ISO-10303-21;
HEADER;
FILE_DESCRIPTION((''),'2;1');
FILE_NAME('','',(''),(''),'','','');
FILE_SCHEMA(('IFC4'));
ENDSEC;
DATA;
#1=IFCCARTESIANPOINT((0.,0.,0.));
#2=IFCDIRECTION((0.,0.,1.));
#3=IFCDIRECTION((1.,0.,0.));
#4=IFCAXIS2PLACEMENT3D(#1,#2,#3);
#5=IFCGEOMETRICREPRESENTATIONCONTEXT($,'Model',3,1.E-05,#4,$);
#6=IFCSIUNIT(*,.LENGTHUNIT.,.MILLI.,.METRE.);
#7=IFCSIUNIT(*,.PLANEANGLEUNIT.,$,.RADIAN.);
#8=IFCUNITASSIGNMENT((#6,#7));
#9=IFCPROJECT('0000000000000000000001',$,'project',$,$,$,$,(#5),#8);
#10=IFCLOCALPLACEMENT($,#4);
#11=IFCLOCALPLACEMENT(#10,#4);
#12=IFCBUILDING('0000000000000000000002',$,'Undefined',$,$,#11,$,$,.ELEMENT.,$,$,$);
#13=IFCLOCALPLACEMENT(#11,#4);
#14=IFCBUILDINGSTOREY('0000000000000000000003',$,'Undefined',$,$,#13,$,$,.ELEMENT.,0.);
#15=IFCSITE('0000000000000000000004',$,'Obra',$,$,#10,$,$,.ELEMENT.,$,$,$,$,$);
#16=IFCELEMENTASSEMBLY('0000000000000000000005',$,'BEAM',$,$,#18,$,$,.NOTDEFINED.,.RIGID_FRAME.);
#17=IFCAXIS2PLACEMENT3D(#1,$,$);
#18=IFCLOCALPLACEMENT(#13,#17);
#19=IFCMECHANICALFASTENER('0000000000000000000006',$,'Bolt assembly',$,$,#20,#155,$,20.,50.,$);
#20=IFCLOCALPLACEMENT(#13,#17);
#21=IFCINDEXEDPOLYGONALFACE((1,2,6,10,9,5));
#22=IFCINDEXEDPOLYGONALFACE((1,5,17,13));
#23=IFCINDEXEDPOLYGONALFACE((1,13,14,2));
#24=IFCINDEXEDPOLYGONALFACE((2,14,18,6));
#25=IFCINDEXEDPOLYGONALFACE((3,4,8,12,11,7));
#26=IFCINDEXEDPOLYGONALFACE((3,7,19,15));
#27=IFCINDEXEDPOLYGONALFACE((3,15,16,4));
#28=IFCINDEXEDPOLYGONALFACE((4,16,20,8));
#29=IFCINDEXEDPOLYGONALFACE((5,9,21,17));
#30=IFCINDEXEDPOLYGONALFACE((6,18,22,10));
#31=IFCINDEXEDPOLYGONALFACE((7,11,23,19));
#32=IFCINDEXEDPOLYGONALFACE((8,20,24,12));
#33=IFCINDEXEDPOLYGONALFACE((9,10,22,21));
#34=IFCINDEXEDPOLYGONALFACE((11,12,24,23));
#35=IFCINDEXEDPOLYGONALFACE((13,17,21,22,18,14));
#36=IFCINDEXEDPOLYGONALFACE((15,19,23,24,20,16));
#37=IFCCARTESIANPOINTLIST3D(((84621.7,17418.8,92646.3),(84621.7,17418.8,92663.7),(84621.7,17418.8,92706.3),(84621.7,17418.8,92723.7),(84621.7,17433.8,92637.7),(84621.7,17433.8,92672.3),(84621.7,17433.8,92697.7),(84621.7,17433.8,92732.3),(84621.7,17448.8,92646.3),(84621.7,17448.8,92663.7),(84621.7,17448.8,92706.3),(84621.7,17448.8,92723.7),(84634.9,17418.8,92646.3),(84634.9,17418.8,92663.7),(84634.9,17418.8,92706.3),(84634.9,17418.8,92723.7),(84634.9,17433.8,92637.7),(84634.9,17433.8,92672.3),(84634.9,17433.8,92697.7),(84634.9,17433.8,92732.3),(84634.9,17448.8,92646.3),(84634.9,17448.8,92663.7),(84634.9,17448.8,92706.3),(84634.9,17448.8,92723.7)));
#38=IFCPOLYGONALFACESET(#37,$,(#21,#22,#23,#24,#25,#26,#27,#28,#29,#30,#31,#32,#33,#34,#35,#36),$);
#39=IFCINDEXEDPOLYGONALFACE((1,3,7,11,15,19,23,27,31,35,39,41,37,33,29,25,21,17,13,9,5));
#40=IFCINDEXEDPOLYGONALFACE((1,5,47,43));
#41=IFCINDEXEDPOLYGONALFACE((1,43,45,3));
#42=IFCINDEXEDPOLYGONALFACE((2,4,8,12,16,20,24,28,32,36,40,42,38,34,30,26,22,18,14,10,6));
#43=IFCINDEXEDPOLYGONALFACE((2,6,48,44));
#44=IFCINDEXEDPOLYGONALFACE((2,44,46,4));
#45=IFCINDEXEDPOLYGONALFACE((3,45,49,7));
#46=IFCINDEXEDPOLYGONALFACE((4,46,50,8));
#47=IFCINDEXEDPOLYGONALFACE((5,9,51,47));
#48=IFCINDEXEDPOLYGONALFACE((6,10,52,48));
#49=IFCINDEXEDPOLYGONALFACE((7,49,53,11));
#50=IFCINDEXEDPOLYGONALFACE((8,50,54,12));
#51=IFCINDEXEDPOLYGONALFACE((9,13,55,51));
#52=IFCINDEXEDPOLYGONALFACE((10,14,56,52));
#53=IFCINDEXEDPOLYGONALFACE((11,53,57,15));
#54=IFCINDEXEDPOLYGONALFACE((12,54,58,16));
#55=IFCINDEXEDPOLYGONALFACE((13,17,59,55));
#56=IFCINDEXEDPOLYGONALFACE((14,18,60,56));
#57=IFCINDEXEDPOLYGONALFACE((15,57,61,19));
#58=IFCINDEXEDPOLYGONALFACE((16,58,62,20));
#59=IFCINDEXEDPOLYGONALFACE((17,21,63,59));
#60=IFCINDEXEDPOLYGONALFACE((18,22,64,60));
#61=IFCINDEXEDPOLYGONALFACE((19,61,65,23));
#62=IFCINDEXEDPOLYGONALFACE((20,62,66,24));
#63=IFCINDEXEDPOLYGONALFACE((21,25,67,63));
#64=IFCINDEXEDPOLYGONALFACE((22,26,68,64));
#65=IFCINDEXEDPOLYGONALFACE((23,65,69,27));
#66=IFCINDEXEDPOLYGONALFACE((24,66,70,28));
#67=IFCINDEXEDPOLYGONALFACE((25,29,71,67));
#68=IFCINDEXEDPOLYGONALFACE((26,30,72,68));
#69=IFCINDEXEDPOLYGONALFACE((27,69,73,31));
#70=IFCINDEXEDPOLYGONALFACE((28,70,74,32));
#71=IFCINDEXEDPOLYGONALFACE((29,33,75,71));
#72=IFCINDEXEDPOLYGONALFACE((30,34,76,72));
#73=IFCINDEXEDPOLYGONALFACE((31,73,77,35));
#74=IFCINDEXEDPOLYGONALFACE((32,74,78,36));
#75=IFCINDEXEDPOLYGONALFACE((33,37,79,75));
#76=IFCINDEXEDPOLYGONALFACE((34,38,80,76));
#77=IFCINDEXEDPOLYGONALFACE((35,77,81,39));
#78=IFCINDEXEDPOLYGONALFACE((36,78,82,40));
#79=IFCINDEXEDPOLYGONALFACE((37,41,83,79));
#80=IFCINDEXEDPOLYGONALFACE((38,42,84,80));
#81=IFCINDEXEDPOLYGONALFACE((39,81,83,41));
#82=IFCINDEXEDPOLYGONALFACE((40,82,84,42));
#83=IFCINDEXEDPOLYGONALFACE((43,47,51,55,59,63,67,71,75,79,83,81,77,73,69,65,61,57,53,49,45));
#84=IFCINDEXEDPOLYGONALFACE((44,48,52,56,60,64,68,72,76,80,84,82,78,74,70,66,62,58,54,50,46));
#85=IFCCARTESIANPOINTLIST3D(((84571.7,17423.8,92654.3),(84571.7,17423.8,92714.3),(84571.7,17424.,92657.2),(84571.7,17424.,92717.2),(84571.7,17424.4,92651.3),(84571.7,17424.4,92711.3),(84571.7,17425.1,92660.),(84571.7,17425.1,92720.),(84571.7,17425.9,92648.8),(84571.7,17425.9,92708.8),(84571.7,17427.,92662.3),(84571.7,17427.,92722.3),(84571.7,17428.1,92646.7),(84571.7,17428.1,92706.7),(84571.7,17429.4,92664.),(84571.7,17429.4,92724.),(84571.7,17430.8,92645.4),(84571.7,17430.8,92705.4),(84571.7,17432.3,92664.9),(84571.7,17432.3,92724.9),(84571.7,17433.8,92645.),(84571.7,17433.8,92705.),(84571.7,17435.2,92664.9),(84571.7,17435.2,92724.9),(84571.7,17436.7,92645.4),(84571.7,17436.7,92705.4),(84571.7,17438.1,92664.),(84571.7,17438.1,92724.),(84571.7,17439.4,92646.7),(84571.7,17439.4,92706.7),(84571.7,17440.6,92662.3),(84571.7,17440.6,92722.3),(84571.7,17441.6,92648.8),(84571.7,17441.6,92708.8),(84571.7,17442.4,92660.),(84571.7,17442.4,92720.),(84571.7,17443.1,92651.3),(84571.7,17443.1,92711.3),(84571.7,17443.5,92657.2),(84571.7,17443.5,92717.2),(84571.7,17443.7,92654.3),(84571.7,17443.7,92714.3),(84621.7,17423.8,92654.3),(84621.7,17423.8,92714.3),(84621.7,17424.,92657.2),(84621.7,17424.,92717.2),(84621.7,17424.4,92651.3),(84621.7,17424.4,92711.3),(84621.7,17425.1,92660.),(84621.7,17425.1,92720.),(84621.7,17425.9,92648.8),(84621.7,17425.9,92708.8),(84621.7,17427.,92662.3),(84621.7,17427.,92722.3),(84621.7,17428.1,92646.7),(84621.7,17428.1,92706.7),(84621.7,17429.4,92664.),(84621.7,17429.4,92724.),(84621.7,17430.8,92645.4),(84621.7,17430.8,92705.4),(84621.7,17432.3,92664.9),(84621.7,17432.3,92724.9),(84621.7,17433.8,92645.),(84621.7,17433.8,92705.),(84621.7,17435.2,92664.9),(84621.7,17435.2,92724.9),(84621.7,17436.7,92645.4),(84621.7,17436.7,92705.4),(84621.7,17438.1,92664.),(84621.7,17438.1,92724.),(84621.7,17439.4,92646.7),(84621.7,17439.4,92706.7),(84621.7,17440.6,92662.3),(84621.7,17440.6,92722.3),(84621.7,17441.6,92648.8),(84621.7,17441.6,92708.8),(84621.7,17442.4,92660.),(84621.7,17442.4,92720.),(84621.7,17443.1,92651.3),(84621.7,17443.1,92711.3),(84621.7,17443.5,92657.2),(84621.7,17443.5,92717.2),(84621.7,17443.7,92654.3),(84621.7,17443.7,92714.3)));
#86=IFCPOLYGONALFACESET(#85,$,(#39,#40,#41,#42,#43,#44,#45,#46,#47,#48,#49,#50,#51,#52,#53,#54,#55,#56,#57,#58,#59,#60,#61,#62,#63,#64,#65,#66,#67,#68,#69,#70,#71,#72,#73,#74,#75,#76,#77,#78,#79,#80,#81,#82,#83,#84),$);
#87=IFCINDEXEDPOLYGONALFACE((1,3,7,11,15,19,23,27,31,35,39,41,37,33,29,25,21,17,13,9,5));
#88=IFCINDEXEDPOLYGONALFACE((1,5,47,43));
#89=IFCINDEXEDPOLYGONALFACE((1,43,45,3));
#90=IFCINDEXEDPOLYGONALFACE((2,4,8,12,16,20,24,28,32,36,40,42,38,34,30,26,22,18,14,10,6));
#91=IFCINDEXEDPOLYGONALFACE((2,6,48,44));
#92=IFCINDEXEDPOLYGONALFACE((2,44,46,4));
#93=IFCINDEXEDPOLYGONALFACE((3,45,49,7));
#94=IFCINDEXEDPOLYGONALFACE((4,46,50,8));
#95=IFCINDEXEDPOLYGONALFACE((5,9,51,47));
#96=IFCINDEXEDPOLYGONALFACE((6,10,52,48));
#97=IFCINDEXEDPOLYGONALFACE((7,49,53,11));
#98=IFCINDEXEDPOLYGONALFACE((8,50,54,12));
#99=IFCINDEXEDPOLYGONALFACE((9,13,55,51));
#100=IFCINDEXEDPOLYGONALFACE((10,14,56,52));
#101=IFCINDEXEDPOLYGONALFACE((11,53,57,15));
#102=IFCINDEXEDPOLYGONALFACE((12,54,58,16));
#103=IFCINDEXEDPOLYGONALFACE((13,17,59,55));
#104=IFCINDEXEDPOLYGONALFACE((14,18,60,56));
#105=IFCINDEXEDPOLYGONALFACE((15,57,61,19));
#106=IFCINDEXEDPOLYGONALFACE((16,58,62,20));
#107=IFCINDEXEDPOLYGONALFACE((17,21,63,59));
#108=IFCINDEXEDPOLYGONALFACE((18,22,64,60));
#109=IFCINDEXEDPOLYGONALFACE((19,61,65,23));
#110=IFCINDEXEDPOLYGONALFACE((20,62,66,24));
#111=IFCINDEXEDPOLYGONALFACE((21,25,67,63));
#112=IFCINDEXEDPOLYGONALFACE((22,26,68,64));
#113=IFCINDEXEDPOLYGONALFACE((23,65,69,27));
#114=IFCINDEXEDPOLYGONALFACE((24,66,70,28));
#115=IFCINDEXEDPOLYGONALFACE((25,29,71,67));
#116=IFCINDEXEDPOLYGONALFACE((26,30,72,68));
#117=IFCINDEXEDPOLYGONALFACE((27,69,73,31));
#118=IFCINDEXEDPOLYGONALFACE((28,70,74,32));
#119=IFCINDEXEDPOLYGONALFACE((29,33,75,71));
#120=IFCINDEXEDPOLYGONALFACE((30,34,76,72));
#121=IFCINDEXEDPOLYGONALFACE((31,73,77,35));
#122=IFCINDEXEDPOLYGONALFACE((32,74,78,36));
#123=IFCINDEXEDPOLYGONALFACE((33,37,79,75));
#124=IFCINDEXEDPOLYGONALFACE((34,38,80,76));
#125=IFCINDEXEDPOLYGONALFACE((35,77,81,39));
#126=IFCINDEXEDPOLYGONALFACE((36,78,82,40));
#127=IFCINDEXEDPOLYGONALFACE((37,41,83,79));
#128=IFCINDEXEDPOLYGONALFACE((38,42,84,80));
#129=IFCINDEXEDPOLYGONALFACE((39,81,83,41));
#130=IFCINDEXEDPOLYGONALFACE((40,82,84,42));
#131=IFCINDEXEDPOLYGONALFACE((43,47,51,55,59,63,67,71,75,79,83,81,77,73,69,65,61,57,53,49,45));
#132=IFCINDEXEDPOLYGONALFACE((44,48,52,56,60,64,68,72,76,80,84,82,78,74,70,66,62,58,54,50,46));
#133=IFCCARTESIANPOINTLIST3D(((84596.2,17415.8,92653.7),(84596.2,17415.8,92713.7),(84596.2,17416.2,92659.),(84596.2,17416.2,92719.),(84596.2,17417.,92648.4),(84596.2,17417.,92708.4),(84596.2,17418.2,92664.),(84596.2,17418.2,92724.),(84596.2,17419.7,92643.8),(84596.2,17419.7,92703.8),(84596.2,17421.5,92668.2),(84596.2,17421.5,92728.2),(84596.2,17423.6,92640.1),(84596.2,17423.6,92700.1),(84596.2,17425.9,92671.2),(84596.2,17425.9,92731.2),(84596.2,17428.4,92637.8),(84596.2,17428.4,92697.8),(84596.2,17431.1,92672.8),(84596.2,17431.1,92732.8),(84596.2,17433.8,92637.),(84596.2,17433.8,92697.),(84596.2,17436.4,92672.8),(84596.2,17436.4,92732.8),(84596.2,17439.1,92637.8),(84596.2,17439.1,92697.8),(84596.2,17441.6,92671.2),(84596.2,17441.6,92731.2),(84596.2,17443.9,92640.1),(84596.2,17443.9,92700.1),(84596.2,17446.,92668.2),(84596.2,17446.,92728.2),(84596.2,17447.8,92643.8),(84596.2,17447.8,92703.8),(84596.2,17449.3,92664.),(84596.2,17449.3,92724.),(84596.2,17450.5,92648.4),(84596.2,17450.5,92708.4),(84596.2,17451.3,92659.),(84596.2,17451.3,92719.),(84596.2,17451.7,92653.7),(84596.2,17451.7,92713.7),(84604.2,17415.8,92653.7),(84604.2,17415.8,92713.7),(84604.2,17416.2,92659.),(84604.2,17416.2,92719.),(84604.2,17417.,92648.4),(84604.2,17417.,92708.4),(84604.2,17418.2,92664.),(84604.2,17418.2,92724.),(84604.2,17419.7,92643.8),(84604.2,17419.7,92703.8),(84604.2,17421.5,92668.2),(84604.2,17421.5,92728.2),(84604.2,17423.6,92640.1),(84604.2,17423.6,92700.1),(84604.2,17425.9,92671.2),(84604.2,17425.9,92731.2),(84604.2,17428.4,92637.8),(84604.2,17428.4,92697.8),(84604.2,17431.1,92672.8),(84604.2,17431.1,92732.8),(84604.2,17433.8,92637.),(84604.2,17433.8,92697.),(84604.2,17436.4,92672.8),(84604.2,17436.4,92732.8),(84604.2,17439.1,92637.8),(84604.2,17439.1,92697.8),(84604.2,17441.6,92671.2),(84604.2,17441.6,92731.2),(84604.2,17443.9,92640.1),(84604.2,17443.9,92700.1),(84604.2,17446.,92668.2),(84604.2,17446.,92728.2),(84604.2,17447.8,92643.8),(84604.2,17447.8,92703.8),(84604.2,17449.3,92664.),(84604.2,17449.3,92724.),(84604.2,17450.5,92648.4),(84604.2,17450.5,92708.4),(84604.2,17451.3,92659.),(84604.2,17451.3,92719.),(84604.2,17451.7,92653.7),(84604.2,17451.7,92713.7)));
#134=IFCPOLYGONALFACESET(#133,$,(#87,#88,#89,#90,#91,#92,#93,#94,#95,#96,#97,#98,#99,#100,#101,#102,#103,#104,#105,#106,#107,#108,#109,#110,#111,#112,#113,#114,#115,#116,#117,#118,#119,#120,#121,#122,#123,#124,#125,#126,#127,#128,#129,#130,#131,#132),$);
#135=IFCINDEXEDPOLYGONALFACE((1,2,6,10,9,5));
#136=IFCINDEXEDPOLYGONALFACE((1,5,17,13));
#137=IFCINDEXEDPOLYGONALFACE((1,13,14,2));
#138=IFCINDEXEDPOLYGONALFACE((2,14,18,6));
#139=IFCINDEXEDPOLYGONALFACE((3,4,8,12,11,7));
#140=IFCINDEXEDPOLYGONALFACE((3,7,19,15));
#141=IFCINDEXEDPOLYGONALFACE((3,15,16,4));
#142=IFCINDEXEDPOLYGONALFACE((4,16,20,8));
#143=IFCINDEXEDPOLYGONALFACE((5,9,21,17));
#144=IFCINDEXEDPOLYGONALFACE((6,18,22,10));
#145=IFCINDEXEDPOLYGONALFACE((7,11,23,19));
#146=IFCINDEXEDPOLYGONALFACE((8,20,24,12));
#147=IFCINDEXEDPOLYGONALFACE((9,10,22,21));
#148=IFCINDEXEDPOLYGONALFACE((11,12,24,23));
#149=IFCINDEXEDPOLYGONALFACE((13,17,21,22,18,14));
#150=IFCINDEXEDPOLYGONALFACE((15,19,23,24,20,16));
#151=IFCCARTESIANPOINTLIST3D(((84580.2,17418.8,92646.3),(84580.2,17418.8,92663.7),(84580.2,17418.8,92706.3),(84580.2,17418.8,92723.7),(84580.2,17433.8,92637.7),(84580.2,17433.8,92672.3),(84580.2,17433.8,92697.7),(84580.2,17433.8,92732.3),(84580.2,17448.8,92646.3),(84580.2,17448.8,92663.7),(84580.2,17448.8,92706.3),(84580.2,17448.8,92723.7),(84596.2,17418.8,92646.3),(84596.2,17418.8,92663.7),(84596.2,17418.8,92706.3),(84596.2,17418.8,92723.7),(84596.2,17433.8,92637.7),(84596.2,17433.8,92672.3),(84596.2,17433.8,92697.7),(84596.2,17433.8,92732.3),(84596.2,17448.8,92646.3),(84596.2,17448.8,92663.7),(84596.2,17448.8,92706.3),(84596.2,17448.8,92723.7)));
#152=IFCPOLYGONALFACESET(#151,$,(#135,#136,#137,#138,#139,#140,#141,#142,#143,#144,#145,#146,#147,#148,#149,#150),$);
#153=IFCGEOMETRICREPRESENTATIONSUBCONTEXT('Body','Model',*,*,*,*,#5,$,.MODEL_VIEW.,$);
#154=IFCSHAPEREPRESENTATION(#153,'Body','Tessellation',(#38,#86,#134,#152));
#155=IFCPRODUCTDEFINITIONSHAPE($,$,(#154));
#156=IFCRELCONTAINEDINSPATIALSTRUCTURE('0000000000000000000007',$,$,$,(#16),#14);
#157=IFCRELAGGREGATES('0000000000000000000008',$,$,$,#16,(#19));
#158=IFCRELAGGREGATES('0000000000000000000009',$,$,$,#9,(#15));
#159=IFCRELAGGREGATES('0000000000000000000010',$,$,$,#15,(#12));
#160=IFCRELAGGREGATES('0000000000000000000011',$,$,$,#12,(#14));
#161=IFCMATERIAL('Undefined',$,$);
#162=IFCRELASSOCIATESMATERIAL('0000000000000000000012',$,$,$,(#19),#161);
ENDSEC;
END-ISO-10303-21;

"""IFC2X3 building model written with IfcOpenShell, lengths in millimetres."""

from ifc_helpers import new_model, si_unit, frame, origin_with_axes, origin_2d_with_axis, place, context, subcontext, project, spatial, polyline, circle, outline, extrude, source, transform, mapped, material, element, aggregate, save


model = new_model("IFC2X3")

# Units and contexts
model_context = context("Model", 3, precision=1e-05, world=origin_with_axes())
body_context = subcontext(model_context, "Body", "Model", "MODEL_VIEW")
ifc_project = project(units=[si_unit("LENGTHUNIT", "METRE", prefix="MILLI"), si_unit("PLANEANGLEUNIT", "RADIAN")], contexts=[model_context])

# Site, building, storey
site_placement = place(None, origin_with_axes())
site = spatial("IfcSite", under=ifc_project, at=site_placement, Name="Obra", CompositionType="ELEMENT")
building_placement = place(site_placement, origin_with_axes())
building = spatial("IfcBuilding", under=site, at=building_placement, Name="Undefined", CompositionType="ELEMENT")
storey_placement = place(building_placement, origin_with_axes())
storey = spatial("IfcBuildingStorey", under=building, at=storey_placement, Name="Undefined", CompositionType="ELEMENT", Elevation=0.0)

# Shared definitions
ifc_material_1 = material(Name="Undefined")

# Element assembly, mechanical fastener
assembly_1_placement = place(storey_placement, origin_with_axes())
assembly_1 = element("IfcElementAssembly", 1, at=assembly_1_placement, inside=storey, Name="BEAM", AssemblyPlace="NOTDEFINED", PredefinedType="RIGID_FRAME")
shared_shape_1 = source(origin_with_axes(), body_context, "Body", "SweptSolid", [
    extrude(outline(polyline([(17.3, 0.0), (8.7, 15.0), (-8.7, 15.0), (-17.3, 0.0), (-8.7, -15.0), (8.7, -15.0), (17.3, 0.0)])), frame((0.0, -27.0, 0.0), z_axis=(0.0, 1.0, 0.0), x_axis=(1.0, 0.0, 0.0)), (0.0, 0.0, 1.0), 13.2),
    extrude(circle(Radius=10.0, at=origin_2d_with_axis()), frame((0.0, -13.8, 0.0), z_axis=(0.0, 1.0, 0.0), x_axis=(1.0, 0.0, 0.0)), (0.0, 0.0, 1.0), 50.0),
    extrude(circle(Radius=18.0, at=origin_2d_with_axis()), frame((0.0, 3.7, 0.0), z_axis=(0.0, 1.0, 0.0), x_axis=(1.0, 0.0, 0.0)), (0.0, 0.0, 1.0), 8.0),
    extrude(outline(polyline([(17.3, 0.0), (8.7, 15.0), (-8.7, 15.0), (-17.3, 0.0), (-8.7, -15.0), (8.7, -15.0), (17.3, 0.0)])), frame((0.0, 11.7, 0.0), z_axis=(0.0, 1.0, 0.0), x_axis=(1.0, 0.0, 0.0)), (0.0, 0.0, 1.0), 16.0),
])
mechanical_fastener_1_placement = place(assembly_1_placement, frame((84607.9, 17393.8, 92850.0), z_axis=(0.0, 1.0, 0.0), x_axis=(0.0, 0.0, -1.0)))
mechanical_fastener_1 = element("IfcMechanicalFastener", 2, at=mechanical_fastener_1_placement, material=ifc_material_1, Name="Bolt assembly", NominalDiameter=20.0, NominalLength=50.0, context=body_context, shape_type="MappedRepresentation", body=[
    mapped(shared_shape_1, transform((135.0, 0.0, 40.0))),
    mapped(shared_shape_1, transform((195.0, 0.0, 40.0))),
])
aggregate(assembly_1, [mechanical_fastener_1])

save(model, "model.ifc")
